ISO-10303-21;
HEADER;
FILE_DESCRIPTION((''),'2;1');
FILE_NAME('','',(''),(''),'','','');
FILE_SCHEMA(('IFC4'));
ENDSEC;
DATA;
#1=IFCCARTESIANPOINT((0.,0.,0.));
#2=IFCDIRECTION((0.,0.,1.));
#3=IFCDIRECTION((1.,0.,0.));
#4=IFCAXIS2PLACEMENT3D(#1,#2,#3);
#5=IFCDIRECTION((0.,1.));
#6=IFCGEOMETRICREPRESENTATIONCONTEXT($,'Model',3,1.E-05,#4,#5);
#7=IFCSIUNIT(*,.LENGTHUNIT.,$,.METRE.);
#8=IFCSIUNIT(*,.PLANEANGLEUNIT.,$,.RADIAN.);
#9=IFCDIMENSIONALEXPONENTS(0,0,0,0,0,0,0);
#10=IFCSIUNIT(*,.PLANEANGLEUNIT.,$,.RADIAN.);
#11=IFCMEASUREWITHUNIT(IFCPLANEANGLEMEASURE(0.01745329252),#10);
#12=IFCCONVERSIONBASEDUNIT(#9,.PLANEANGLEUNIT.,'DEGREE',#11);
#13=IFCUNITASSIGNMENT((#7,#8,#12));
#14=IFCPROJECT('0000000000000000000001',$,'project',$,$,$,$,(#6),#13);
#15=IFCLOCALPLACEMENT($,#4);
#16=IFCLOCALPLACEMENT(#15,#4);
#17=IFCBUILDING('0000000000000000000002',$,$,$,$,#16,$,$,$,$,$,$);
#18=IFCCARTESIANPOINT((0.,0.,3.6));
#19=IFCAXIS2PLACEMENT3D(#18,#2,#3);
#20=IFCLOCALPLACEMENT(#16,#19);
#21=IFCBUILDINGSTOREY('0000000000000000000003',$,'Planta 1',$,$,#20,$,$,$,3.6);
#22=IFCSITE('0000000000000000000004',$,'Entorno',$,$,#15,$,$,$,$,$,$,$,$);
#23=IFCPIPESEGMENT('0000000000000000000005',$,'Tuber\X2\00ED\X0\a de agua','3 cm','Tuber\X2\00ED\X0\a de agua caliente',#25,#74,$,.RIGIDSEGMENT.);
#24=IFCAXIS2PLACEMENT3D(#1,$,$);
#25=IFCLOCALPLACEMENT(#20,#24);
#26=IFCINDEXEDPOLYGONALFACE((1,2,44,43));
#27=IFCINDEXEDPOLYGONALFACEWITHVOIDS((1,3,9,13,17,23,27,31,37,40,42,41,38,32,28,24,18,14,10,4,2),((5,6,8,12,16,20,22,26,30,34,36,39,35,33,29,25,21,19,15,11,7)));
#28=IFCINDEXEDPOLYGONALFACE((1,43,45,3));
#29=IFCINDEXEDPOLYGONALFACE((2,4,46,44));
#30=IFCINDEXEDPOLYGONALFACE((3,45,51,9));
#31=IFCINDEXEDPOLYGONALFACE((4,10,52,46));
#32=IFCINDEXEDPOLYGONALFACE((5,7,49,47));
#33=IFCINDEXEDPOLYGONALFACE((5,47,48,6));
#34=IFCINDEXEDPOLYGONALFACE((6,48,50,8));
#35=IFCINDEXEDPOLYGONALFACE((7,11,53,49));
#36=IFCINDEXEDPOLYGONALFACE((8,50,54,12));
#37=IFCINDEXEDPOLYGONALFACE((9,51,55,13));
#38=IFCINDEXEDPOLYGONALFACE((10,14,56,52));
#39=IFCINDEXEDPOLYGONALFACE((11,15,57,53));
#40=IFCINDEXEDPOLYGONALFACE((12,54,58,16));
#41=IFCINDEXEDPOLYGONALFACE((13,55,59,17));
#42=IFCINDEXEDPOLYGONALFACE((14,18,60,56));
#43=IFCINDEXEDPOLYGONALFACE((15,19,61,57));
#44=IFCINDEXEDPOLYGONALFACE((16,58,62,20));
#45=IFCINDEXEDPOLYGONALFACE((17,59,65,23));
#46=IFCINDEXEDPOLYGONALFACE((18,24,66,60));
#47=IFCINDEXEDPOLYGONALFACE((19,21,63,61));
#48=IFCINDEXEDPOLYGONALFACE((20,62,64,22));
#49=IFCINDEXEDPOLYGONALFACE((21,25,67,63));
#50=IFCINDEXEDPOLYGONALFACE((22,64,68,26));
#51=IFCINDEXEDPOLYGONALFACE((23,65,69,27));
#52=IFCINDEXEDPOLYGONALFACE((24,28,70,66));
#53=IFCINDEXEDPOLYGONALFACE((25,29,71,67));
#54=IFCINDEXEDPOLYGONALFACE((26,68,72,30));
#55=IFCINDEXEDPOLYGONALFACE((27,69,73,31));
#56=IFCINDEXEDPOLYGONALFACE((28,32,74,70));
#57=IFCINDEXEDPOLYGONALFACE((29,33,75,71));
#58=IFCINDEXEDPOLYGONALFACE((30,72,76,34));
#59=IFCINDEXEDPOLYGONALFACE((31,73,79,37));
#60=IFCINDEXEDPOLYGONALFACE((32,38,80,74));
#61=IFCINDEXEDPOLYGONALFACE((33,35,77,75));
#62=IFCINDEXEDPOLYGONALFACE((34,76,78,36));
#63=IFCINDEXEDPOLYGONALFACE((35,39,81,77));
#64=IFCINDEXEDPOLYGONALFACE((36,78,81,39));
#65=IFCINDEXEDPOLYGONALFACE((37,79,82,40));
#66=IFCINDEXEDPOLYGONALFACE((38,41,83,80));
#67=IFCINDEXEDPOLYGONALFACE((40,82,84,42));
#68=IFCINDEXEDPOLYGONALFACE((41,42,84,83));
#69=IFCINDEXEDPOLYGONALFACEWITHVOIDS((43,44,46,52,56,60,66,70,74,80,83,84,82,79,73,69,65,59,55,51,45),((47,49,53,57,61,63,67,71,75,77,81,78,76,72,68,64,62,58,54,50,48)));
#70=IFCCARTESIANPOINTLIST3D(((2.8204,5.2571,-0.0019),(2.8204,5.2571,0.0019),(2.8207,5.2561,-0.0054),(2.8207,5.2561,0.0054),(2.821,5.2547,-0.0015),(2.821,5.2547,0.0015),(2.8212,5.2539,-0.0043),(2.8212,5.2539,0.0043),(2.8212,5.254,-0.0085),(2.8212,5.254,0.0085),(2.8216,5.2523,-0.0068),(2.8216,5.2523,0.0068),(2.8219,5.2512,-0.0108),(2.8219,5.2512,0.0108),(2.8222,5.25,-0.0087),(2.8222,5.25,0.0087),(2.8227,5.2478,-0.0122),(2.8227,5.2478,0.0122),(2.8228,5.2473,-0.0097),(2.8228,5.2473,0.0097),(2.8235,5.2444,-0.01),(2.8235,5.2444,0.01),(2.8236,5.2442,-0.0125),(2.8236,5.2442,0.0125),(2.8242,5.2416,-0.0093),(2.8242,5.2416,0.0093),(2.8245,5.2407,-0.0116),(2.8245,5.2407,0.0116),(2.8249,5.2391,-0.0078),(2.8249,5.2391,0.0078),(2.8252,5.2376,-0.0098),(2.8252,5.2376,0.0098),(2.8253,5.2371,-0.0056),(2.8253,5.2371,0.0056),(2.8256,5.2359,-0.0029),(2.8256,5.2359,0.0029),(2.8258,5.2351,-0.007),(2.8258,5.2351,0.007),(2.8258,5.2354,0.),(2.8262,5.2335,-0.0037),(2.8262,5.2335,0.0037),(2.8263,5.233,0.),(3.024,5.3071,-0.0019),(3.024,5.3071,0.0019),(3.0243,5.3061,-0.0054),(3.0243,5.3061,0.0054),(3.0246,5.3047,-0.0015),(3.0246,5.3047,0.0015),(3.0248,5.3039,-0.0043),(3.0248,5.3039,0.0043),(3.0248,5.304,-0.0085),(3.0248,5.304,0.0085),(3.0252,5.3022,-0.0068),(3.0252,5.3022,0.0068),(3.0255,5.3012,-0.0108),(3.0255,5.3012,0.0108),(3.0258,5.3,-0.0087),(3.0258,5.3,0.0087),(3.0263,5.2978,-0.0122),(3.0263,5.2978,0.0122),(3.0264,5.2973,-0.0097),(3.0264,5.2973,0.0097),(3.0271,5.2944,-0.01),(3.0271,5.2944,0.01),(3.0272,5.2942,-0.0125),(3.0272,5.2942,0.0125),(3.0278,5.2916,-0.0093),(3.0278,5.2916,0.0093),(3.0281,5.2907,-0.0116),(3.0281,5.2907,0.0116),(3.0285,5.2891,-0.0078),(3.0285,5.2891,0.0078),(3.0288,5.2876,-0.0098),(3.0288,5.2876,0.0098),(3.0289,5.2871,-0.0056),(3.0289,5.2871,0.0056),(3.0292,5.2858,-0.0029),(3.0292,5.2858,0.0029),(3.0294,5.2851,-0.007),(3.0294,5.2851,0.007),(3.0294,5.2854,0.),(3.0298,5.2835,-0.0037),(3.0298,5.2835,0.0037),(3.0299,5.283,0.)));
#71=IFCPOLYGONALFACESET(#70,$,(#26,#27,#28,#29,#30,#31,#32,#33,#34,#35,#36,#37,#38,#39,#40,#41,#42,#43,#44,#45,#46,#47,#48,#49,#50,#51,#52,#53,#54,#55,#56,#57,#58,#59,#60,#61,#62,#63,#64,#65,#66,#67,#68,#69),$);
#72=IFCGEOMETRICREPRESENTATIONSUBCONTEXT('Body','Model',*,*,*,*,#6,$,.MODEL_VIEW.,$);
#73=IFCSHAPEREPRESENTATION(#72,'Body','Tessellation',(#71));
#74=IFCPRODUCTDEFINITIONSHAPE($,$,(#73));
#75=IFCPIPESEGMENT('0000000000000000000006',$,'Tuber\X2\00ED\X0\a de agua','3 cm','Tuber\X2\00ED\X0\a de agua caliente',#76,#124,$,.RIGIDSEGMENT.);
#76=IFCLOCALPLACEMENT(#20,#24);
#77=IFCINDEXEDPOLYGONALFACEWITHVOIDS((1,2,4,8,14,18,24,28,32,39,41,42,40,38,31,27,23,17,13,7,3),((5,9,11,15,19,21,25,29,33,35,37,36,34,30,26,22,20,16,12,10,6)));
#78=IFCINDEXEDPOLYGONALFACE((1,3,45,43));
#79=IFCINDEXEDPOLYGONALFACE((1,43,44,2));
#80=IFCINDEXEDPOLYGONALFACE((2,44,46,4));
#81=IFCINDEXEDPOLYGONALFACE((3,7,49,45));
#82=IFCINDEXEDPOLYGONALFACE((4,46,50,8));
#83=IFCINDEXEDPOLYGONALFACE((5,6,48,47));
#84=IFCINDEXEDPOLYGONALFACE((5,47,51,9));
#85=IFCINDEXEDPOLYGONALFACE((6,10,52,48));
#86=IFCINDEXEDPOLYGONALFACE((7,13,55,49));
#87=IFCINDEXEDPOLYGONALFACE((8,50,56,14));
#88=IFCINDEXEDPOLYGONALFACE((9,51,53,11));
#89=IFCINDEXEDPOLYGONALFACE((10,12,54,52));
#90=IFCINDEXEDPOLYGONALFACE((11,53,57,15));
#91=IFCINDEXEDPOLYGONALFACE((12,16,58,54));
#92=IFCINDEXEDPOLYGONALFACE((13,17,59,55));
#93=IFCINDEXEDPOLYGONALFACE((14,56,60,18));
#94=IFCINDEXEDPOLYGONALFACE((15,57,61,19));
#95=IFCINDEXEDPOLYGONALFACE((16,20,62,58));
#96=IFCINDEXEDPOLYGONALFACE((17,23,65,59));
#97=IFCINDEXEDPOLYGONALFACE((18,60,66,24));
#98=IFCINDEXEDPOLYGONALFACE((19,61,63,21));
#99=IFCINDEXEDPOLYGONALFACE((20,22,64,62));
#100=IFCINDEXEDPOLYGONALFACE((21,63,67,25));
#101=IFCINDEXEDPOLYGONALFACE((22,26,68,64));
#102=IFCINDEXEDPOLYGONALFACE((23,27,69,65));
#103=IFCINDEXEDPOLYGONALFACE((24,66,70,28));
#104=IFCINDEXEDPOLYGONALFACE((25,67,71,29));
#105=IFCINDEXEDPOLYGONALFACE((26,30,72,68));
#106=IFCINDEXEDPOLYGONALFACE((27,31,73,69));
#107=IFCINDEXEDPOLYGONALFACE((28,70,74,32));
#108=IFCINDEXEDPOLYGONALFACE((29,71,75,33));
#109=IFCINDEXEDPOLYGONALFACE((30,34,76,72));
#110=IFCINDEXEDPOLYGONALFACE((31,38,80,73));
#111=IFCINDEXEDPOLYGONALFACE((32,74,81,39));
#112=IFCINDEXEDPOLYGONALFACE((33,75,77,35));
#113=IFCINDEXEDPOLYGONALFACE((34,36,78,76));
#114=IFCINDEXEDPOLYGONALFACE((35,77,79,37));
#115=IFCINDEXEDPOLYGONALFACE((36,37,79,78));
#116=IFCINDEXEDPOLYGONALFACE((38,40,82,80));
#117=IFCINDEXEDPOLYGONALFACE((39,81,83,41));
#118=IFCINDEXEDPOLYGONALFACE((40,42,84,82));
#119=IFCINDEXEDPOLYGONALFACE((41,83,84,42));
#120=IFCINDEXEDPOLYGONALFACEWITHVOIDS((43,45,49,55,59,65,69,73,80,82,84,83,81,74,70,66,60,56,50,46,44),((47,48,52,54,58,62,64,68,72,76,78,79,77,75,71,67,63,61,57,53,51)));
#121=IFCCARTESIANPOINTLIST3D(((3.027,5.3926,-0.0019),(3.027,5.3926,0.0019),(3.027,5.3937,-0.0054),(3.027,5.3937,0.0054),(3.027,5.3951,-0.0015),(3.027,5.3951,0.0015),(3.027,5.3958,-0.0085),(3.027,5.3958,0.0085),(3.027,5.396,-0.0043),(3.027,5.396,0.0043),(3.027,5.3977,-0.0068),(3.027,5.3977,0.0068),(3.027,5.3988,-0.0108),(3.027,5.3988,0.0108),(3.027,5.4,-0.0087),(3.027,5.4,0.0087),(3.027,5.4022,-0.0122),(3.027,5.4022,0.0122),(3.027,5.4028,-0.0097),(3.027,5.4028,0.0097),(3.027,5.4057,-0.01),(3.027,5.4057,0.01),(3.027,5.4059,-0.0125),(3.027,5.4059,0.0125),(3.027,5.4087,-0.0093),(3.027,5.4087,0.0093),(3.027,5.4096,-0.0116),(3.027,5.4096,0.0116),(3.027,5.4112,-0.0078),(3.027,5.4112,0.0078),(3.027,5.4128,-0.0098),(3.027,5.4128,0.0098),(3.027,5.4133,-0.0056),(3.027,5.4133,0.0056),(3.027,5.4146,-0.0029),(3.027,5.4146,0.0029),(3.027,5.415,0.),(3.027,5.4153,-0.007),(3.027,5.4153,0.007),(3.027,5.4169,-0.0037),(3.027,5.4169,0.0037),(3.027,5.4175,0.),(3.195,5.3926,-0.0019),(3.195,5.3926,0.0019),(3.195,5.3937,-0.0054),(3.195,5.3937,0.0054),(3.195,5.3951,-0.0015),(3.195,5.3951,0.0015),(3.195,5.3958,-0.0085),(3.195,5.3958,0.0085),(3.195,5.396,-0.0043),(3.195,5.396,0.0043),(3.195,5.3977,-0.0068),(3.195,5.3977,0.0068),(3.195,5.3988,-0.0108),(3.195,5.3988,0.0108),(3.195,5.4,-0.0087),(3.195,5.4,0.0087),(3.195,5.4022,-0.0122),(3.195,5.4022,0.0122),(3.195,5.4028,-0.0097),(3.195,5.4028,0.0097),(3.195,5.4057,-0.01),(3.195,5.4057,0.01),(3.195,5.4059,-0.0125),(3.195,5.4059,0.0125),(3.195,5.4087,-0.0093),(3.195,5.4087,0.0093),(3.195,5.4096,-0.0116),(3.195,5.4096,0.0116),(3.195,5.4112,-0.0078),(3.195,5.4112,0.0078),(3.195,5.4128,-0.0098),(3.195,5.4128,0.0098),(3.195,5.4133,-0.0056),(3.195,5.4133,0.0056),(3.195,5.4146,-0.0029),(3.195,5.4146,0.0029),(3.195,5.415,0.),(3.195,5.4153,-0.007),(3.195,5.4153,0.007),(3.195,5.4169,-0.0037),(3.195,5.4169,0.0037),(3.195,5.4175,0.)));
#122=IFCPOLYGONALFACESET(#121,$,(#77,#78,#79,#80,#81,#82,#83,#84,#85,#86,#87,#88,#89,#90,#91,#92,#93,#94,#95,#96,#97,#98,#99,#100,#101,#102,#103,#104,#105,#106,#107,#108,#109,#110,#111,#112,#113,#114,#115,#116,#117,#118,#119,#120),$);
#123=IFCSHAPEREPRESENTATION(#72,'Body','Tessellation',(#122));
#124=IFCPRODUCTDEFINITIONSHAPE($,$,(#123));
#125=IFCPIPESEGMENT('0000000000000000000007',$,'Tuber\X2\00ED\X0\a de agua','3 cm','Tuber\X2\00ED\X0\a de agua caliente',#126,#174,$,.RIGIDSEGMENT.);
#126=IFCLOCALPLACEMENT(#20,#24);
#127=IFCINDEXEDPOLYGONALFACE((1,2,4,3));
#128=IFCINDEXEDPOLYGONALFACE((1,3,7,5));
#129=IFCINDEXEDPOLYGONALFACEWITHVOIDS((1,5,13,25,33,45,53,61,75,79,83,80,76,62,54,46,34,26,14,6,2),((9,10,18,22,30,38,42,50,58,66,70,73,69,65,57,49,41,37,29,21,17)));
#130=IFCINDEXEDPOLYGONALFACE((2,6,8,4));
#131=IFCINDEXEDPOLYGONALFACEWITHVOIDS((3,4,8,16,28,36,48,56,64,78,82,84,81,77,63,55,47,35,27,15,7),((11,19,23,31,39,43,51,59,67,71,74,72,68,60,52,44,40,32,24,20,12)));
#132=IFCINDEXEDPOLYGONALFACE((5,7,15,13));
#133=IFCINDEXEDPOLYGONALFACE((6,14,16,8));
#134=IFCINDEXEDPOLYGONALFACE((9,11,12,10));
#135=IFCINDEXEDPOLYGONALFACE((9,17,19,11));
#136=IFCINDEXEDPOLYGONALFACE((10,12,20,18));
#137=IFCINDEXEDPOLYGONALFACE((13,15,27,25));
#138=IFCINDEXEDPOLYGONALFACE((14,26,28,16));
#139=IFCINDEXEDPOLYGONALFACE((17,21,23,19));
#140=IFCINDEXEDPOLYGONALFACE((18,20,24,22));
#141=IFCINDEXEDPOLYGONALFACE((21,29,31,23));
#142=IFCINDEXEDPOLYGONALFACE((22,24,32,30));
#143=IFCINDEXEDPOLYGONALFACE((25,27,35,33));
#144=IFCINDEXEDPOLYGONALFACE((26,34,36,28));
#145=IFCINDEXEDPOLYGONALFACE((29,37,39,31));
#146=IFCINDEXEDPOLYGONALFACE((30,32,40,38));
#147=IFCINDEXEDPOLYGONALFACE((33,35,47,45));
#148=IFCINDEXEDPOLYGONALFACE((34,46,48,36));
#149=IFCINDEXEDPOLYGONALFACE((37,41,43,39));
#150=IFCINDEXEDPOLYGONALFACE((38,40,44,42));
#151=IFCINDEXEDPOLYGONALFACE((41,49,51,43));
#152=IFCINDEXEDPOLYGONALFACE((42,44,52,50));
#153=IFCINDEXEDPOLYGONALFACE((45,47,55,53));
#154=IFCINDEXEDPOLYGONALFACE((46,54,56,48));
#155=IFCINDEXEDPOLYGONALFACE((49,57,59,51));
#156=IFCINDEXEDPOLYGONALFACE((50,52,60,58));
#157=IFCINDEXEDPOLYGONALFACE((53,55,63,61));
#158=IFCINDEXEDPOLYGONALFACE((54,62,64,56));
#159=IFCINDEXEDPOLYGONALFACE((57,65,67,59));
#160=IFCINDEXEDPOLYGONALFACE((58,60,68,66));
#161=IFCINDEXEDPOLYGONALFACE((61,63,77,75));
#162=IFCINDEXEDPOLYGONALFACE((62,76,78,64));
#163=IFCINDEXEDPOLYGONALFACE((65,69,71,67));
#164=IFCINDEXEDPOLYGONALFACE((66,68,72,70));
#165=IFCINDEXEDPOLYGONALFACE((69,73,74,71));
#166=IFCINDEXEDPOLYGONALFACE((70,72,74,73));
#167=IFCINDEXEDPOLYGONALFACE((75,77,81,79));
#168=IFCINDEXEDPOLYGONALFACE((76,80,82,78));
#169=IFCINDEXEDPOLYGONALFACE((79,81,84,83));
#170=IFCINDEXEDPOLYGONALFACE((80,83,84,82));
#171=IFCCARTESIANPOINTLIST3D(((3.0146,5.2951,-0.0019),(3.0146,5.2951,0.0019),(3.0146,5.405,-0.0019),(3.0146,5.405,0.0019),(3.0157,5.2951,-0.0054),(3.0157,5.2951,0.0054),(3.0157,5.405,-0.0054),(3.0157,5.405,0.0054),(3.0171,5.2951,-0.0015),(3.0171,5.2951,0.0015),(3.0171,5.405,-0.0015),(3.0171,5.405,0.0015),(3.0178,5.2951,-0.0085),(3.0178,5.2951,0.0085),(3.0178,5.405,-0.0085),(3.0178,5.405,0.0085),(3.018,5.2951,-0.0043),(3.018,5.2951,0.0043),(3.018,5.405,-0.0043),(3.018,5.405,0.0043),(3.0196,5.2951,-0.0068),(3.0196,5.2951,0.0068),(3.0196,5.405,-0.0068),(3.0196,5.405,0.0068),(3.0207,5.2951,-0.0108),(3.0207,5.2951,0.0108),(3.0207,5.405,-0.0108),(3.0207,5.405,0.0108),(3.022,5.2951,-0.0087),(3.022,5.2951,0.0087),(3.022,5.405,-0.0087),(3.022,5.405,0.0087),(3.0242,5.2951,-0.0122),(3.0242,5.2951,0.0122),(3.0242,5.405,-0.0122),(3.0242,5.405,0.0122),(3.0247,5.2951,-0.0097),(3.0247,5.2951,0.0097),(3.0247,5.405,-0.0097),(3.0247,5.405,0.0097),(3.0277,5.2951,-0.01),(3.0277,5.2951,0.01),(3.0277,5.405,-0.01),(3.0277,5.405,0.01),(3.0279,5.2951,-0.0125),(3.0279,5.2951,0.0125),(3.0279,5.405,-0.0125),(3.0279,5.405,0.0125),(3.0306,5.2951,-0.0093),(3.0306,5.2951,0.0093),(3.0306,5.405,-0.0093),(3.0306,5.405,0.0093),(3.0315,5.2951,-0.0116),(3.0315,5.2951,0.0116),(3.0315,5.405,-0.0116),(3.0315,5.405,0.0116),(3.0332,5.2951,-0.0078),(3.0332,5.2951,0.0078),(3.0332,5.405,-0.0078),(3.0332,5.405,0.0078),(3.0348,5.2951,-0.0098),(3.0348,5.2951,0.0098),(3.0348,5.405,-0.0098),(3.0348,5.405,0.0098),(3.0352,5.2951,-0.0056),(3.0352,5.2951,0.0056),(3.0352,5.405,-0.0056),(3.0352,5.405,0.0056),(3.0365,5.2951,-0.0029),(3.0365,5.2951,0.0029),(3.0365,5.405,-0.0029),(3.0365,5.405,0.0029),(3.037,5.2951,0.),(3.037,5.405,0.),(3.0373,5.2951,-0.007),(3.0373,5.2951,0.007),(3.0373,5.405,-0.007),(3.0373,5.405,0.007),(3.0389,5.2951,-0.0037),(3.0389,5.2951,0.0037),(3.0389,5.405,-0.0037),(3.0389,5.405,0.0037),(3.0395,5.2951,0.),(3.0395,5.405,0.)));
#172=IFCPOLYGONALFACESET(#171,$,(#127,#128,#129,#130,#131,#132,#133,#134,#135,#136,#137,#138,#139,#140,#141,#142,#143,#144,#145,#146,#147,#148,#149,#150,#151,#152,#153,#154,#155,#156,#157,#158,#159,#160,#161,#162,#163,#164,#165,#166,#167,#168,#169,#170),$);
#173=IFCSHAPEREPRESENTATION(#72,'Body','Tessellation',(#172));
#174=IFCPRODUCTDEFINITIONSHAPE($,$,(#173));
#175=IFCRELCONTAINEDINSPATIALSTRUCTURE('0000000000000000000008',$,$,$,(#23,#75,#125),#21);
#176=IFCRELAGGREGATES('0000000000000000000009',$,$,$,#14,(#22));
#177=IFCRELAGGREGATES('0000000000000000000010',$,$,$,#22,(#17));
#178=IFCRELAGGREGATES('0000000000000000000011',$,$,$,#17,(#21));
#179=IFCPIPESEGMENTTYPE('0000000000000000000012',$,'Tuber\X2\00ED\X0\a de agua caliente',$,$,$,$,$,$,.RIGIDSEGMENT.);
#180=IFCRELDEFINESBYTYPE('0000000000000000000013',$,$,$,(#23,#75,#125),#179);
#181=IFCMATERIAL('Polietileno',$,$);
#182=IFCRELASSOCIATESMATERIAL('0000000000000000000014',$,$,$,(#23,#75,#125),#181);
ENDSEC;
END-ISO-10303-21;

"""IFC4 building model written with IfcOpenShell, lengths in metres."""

from ifc_helpers import new_model, entity, si_unit, converted_unit, direction, frame, origin_with_axes, origin_2d_with_axis, place, context, subcontext, project, spatial, hollow_circle, extrude, material, type_object, element, save


model = new_model("IFC4")

# Units and contexts
model_context = context("Model", 3, precision=1e-05, world=origin_with_axes(), true_north=direction((0.0, 1.0)))
body_context = subcontext(model_context, "Body", "Model", "MODEL_VIEW")
ifc_project = project(units=[si_unit("LENGTHUNIT", "METRE"), si_unit("PLANEANGLEUNIT", "RADIAN"), converted_unit("PLANEANGLEUNIT", "DEGREE", entity("IfcPlaneAngleMeasure", 0.01745329252), si_unit("PLANEANGLEUNIT", "RADIAN"), dimensions=[0, 0, 0, 0, 0, 0, 0])], contexts=[model_context])

# Site, building, storey
site_placement = place(None, origin_with_axes())
site = spatial("IfcSite", under=ifc_project, at=site_placement, Name="Entorno")
building_placement = place(site_placement, origin_with_axes())
building = spatial("IfcBuilding", under=site, at=building_placement)
storey_placement = place(building_placement, frame((0.0, 0.0, 3.6), z_axis=(0.0, 0.0, 1.0), x_axis=(1.0, 0.0, 0.0)))
storey = spatial("IfcBuildingStorey", under=building, at=storey_placement, Name="Planta 1", Elevation=3.6)

# Pipe segments
ifc_material_1 = material(Name="Polietileno")
pipe_segment_type_1 = type_object("IfcPipeSegmentType", Name="Tubería de agua caliente", PredefinedType="RIGIDSEGMENT")
pipe_segment_1_placement = place(storey_placement, frame((3.027, 5.2951, 0.0), z_axis=(-0.971159, -0.238431, 0.0), x_axis=(0.238431, -0.971159, 0.0)))
element("IfcPipeSegment", 1, at=pipe_segment_1_placement, inside=storey, type_object=pipe_segment_type_1, material=ifc_material_1, Name="Tubería de agua", Description="3 cm", ObjectType="Tubería de agua caliente", PredefinedType="RIGIDSEGMENT", context=body_context, shape_type="SweptSolid", body=[
    extrude(hollow_circle(Radius=0.0125, WallThickness=0.0025, at=origin_2d_with_axis()), origin_with_axes(), (0.0, 0.0, 1.0), 0.2096),
])
pipe_segment_2_placement = place(storey_placement, frame((3.027, 5.405, 0.0), z_axis=(1.0, 0.0, 0.0), x_axis=(0.0, 1.0, 0.0)))
element("IfcPipeSegment", 2, at=pipe_segment_2_placement, inside=storey, type_object=pipe_segment_type_1, material=ifc_material_1, Name="Tubería de agua", Description="3 cm", ObjectType="Tubería de agua caliente", PredefinedType="RIGIDSEGMENT", context=body_context, shape_type="SweptSolid", body=[
    extrude(hollow_circle(Radius=0.0125, WallThickness=0.0025, at=origin_2d_with_axis()), origin_with_axes(), (0.0, 0.0, 1.0), 0.168),
])
pipe_segment_3_placement = place(storey_placement, frame((3.027, 5.405, 0.0), z_axis=(0.0, -1.0, 0.0), x_axis=(1.0, 0.0, 0.0)))
element("IfcPipeSegment", 3, at=pipe_segment_3_placement, inside=storey, type_object=pipe_segment_type_1, material=ifc_material_1, Name="Tubería de agua", Description="3 cm", ObjectType="Tubería de agua caliente", PredefinedType="RIGIDSEGMENT", context=body_context, shape_type="SweptSolid", body=[
    extrude(hollow_circle(Radius=0.0125, WallThickness=0.0025, at=origin_2d_with_axis()), origin_with_axes(), (0.0, 0.0, 1.0), 0.1099),
])

save(model, "model.ifc")
